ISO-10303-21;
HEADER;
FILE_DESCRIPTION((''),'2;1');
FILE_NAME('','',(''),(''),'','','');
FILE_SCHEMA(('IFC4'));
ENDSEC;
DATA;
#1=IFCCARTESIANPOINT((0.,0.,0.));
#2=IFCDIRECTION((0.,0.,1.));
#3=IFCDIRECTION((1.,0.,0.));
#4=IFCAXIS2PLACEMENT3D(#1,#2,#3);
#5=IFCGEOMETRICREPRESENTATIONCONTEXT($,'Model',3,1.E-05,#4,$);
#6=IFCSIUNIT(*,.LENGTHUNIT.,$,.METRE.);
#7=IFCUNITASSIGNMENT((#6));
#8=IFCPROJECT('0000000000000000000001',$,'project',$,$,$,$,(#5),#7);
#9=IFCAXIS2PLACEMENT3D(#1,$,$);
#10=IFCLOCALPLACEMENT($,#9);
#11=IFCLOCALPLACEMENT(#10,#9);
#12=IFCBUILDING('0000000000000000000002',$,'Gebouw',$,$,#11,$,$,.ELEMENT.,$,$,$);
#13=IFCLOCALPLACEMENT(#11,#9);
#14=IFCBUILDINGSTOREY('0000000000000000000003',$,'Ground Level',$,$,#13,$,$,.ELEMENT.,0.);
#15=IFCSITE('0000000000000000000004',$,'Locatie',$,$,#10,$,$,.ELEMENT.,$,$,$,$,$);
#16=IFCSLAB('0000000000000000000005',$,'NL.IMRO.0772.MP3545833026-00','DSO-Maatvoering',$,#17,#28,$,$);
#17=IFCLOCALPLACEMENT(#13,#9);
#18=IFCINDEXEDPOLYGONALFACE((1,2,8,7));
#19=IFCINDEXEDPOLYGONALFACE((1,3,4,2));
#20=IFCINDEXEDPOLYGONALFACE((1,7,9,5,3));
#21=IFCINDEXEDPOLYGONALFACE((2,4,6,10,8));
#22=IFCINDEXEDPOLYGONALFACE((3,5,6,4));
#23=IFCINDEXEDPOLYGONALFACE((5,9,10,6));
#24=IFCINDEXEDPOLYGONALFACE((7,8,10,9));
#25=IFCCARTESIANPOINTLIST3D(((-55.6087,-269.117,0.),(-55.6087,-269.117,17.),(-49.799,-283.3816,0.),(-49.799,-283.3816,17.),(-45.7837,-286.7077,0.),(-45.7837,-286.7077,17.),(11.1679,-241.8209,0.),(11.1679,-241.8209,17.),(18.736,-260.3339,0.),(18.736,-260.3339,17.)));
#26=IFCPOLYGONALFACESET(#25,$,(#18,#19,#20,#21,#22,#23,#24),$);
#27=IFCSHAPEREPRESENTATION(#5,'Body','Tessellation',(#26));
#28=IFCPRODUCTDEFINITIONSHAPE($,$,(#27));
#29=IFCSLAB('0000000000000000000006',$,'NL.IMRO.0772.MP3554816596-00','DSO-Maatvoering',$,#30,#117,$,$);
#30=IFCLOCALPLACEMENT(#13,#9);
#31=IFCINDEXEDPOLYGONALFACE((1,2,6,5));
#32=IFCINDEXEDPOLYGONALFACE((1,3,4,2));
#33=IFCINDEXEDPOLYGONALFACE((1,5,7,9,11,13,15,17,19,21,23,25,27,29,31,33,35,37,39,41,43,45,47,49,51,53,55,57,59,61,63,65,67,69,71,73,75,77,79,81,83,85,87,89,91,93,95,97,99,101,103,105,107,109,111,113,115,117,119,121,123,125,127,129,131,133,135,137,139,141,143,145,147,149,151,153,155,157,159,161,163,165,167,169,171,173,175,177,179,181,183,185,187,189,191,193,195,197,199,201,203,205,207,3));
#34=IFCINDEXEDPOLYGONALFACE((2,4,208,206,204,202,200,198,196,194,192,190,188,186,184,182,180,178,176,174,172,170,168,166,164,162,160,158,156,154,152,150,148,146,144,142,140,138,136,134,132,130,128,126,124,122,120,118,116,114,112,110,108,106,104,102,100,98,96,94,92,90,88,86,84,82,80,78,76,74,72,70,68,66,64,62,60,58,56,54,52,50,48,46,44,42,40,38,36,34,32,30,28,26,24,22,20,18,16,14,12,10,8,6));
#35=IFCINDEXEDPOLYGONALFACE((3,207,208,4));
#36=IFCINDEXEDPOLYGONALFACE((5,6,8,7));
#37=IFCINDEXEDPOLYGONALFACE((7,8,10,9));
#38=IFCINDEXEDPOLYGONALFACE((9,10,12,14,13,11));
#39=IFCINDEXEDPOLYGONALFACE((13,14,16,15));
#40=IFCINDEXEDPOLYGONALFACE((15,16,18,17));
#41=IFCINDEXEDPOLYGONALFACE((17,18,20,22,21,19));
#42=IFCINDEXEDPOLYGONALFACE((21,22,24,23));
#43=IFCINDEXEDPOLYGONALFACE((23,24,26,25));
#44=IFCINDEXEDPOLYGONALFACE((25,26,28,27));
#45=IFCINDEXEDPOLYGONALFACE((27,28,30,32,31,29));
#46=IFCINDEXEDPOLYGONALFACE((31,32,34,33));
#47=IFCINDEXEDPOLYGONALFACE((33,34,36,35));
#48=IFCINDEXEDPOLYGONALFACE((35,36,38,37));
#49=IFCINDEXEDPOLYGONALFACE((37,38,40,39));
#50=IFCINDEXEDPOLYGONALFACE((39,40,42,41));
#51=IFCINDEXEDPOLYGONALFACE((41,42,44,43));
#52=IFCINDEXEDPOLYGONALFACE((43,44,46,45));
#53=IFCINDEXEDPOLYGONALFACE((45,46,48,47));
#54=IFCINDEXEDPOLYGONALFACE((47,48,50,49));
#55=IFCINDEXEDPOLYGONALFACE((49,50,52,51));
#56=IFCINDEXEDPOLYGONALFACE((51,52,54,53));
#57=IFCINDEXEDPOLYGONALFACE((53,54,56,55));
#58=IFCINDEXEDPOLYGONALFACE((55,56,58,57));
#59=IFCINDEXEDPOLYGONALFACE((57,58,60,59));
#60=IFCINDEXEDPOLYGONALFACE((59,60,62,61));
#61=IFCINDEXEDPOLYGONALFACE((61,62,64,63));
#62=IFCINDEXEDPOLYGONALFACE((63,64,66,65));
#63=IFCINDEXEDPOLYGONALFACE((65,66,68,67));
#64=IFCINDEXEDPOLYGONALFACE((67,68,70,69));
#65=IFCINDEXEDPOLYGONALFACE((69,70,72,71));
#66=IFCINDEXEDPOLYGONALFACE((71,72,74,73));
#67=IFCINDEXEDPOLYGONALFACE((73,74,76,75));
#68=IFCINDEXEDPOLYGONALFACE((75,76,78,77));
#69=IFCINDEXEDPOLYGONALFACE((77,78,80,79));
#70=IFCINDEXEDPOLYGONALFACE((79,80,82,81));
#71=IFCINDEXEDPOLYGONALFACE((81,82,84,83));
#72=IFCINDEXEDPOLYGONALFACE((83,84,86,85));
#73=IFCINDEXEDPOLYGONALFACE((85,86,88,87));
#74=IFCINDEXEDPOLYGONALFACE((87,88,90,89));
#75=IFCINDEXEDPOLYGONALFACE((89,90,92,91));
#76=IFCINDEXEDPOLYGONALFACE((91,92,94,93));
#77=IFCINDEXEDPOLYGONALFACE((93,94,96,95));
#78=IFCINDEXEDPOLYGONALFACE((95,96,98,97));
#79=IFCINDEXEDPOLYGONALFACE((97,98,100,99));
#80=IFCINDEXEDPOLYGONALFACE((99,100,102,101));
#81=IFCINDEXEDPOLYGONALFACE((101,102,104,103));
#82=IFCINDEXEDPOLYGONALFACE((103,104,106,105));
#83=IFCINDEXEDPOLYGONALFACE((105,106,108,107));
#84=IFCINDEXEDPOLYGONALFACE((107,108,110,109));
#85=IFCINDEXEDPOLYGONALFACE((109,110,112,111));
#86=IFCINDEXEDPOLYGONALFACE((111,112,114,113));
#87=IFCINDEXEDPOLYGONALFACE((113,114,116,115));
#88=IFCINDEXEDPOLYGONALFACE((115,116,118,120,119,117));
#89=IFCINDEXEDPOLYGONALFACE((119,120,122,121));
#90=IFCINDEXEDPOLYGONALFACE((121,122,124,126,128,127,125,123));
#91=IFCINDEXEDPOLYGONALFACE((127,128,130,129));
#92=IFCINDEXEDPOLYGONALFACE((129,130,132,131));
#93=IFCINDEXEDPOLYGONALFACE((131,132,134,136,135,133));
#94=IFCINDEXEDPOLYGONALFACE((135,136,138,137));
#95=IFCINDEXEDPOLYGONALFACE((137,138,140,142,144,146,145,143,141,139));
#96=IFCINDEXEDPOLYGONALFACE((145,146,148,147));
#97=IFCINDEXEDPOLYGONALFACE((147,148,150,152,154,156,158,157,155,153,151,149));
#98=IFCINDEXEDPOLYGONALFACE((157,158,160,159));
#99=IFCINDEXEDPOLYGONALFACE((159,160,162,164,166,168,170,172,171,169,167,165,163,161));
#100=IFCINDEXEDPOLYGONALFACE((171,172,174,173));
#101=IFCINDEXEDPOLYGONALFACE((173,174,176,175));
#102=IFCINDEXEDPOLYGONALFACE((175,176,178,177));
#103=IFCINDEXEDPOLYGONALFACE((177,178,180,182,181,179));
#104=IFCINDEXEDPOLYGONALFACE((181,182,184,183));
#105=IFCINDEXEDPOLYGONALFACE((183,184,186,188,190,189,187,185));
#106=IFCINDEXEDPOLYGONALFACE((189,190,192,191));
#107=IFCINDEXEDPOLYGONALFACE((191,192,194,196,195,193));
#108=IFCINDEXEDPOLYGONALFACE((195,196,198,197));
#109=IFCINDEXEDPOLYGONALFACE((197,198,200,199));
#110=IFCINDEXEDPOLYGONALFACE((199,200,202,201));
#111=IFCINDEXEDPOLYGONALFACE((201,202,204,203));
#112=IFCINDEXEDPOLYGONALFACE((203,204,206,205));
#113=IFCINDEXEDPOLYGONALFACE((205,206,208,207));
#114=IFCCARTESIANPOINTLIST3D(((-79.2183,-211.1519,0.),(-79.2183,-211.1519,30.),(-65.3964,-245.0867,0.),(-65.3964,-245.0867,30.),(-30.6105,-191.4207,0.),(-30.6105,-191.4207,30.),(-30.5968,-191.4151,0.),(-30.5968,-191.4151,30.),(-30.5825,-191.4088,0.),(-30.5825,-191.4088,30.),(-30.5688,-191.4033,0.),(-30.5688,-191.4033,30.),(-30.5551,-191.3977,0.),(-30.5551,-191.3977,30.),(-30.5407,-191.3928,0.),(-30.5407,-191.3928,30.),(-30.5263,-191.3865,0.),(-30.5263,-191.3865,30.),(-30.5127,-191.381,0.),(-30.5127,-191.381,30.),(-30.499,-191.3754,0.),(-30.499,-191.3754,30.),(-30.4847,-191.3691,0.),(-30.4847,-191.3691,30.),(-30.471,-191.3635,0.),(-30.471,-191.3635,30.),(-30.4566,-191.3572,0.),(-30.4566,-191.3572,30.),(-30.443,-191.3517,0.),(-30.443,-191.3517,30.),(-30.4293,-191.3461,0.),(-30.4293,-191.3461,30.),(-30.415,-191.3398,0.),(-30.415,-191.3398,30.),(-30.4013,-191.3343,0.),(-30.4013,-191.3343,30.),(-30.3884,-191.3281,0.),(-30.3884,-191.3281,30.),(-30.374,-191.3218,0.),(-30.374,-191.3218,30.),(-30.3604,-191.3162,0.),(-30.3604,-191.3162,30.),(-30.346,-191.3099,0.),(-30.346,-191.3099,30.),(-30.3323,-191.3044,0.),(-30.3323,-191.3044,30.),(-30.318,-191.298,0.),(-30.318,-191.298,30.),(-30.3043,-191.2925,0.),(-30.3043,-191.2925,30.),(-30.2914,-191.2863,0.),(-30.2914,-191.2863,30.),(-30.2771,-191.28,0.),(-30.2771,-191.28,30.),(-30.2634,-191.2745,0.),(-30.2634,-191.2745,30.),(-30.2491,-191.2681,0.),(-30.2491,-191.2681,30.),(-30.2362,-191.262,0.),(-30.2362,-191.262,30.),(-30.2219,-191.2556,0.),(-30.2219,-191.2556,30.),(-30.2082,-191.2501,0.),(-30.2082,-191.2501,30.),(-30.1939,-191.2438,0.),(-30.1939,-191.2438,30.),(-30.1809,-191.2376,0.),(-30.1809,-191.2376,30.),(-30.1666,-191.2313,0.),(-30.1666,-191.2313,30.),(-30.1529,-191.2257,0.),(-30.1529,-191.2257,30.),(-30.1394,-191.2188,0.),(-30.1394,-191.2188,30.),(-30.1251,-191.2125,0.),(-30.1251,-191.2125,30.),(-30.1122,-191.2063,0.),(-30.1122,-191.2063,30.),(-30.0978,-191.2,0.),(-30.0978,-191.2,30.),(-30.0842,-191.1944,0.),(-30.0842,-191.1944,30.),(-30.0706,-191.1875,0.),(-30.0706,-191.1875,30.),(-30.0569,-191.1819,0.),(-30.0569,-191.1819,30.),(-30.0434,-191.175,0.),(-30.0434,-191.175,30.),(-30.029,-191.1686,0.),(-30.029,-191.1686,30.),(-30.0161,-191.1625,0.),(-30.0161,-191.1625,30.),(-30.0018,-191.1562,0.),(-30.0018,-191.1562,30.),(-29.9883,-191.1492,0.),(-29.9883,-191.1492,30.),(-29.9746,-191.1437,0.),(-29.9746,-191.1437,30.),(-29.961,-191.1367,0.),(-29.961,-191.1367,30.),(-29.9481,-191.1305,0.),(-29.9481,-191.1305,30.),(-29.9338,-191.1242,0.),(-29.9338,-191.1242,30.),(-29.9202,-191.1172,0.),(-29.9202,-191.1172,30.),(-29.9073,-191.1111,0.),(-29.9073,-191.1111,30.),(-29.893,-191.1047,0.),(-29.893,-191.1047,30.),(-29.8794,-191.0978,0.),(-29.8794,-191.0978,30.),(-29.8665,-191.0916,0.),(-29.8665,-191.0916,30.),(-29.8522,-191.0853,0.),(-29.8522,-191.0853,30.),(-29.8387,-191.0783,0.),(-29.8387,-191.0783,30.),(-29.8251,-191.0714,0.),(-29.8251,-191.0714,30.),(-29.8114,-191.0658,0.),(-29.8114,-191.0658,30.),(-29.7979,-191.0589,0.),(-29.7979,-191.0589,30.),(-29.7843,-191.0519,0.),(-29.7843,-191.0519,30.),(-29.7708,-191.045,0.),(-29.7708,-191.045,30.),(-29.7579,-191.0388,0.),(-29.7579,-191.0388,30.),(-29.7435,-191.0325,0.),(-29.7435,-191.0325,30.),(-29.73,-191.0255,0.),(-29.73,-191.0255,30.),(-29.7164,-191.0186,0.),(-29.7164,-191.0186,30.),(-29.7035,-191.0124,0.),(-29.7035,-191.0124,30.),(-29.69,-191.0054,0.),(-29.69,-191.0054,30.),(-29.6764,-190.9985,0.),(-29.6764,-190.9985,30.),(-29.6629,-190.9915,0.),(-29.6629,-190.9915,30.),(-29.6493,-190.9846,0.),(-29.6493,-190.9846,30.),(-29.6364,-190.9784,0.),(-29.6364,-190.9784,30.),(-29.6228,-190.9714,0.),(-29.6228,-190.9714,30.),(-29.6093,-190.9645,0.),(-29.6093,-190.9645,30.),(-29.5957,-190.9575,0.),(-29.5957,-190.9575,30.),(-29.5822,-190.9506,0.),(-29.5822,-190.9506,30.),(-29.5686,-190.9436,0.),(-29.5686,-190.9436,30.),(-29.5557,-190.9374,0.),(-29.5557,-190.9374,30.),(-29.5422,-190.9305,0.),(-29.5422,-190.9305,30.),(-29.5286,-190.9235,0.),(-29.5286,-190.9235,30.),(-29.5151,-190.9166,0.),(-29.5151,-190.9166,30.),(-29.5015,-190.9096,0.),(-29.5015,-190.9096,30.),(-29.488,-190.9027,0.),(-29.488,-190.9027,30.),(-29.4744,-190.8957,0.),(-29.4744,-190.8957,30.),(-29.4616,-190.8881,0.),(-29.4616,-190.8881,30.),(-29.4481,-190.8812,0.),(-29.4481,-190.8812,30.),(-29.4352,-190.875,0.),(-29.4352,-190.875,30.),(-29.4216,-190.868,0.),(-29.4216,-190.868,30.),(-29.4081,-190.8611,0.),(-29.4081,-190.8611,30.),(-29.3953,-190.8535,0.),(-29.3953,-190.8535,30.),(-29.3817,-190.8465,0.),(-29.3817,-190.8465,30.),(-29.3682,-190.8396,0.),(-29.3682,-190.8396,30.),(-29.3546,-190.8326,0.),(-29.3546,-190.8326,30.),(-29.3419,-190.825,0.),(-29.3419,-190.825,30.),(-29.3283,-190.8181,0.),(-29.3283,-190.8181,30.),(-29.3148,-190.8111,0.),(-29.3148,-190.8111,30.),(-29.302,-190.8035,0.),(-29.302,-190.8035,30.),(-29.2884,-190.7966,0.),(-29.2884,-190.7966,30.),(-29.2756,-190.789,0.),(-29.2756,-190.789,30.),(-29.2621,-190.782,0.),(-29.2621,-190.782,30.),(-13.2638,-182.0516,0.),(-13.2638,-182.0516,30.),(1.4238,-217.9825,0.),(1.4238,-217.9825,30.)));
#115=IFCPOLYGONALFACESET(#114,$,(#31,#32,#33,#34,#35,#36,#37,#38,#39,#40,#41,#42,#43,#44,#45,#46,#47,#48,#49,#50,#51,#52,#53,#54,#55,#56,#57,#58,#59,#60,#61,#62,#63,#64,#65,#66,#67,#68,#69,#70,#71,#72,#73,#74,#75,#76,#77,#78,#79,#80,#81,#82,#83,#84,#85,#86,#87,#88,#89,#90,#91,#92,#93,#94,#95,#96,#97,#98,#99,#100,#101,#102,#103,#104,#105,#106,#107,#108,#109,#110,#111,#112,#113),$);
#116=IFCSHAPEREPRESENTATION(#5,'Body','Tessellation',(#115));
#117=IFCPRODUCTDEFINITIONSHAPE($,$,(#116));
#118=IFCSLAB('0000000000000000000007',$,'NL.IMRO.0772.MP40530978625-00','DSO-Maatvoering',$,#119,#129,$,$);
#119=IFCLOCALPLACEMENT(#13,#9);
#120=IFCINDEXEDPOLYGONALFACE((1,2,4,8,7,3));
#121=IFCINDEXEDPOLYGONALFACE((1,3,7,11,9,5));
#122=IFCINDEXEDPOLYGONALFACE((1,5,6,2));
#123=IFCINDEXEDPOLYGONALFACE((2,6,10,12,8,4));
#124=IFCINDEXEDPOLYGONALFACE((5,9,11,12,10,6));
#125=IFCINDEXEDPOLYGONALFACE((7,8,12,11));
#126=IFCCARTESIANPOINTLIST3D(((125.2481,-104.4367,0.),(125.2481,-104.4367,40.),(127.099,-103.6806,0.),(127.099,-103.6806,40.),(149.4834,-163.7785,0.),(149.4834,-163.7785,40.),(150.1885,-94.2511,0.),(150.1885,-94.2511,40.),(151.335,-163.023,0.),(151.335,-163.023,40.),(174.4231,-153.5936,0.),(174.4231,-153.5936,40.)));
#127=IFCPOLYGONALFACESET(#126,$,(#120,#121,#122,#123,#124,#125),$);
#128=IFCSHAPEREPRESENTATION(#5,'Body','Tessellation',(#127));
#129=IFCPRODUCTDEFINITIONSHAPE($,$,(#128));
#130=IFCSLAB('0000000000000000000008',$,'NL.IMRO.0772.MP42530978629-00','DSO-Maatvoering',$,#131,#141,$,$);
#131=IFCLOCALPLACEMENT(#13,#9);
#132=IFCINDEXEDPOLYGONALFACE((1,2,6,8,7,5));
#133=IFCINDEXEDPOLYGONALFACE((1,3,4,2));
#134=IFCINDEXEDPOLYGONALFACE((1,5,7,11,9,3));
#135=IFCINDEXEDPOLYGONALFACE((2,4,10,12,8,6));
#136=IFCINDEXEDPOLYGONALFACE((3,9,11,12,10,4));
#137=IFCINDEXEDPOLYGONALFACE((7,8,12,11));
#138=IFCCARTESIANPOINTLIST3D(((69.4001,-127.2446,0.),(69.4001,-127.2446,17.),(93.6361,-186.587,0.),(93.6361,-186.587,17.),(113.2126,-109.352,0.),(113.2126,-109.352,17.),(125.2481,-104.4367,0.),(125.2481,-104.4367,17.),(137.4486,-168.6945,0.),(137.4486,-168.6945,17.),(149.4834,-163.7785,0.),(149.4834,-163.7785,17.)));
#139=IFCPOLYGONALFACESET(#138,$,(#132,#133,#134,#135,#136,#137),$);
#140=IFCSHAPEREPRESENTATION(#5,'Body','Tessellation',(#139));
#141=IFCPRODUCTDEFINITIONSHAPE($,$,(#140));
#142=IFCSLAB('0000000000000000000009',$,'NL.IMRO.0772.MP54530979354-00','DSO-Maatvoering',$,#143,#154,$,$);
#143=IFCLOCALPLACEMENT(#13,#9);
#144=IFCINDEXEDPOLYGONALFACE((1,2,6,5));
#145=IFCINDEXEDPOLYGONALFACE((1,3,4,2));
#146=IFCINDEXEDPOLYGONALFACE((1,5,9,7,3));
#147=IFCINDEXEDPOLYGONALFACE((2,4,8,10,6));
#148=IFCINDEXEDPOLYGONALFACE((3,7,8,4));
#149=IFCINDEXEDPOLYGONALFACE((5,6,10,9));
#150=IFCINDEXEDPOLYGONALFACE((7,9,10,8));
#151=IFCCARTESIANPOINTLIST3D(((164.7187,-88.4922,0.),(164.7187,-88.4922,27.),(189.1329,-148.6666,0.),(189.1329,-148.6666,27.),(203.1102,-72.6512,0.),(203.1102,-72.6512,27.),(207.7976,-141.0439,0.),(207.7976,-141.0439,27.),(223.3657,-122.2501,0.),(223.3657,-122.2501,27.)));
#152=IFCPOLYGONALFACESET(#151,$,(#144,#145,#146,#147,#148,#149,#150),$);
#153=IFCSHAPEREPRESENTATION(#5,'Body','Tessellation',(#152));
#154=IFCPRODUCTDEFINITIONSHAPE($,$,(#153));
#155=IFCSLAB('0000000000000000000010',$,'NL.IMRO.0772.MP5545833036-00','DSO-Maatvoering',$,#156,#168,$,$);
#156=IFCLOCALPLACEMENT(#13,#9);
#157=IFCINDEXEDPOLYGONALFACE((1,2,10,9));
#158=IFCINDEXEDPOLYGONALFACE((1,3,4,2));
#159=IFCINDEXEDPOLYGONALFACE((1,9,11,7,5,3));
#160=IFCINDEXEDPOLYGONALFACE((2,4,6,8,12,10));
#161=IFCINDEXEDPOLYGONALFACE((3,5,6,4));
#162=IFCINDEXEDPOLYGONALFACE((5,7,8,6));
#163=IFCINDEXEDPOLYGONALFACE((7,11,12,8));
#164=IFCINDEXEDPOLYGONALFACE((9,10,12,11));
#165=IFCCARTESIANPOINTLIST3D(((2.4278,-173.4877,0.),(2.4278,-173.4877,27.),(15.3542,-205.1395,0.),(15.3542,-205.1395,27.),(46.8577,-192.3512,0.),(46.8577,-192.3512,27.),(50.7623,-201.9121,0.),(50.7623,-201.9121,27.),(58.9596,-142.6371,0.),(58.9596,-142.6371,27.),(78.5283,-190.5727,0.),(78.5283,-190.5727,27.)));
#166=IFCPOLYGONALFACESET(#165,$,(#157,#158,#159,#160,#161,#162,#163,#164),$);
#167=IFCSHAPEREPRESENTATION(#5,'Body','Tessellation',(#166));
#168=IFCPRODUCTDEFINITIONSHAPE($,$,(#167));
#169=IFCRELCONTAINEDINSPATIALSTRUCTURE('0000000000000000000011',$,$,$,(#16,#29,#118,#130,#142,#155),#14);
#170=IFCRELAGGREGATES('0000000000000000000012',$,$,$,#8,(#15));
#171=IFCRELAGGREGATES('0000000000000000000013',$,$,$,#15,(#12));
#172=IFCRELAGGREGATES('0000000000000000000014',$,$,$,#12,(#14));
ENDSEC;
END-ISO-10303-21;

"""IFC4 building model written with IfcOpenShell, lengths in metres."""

from ifc_helpers import new_model, si_unit, origin, origin_with_axes, place, context, project, spatial, polyline, outline, extrude, element, save


model = new_model("IFC4")

# Units and contexts
model_context = context("Model", 3, precision=1e-05, world=origin_with_axes())
ifc_project = project(units=[si_unit("LENGTHUNIT", "METRE")], contexts=[model_context])

# Site, building, storey
site_placement = place(None, origin())
site = spatial("IfcSite", under=ifc_project, at=site_placement, Name="Locatie", CompositionType="ELEMENT")
building_placement = place(site_placement, origin())
building = spatial("IfcBuilding", under=site, at=building_placement, Name="Gebouw", CompositionType="ELEMENT")
storey_placement = place(building_placement, origin())
storey = spatial("IfcBuildingStorey", under=building, at=storey_placement, Name="Ground Level", CompositionType="ELEMENT", Elevation=0.0)

# Slabs
slab_1_placement = place(storey_placement, origin())
element("IfcSlab", 1, at=slab_1_placement, inside=storey, Name="NL.IMRO.0772.MP3545833026-00", Description="DSO-Maatvoering", context=model_context, shape_type="SweptSolid", body=[
    extrude(outline(polyline([(-55.6087, -269.117), (11.1679, -241.8209), (18.736, -260.3339), (-45.7837, -286.7077), (-49.799, -283.3816), (-55.6087, -269.117)])), origin_with_axes(), (0.0, 0.0, 1.0), 17.0),
])
slab_2_placement = place(storey_placement, origin())
element("IfcSlab", 2, at=slab_2_placement, inside=storey, Name="NL.IMRO.0772.MP3554816596-00", Description="DSO-Maatvoering", context=model_context, shape_type="SweptSolid", body=[
    extrude(outline(polyline([(-13.2638, -182.0516), (1.4238, -217.9825), (-65.3964, -245.0867), (-79.2183, -211.1519), (-30.6105, -191.4207), (-30.5968, -191.4151), (-30.5825, -191.4088), (-30.5688, -191.4033), (-30.5551, -191.3977), (-30.5407, -191.3928), (-30.5263, -191.3865), (-30.5127, -191.381), (-30.499, -191.3754), (-30.4847, -191.3691), (-30.471, -191.3635), (-30.4566, -191.3572), (-30.443, -191.3517), (-30.4293, -191.3461), (-30.415, -191.3398), (-30.4013, -191.3343), (-30.3884, -191.3281), (-30.374, -191.3218), (-30.3604, -191.3162), (-30.346, -191.3099), (-30.3323, -191.3044), (-30.318, -191.298), (-30.3043, -191.2925), (-30.2914, -191.2863), (-30.2771, -191.28), (-30.2634, -191.2745), (-30.2491, -191.2681), (-30.2362, -191.262), (-30.2219, -191.2556), (-30.2082, -191.2501), (-30.1939, -191.2438), (-30.1809, -191.2376), (-30.1666, -191.2313), (-30.1529, -191.2257), (-30.1394, -191.2188), (-30.1251, -191.2125), (-30.1122, -191.2063), (-30.0978, -191.2), (-30.0842, -191.1944), (-30.0706, -191.1875), (-30.0569, -191.1819), (-30.0434, -191.175), (-30.029, -191.1686), (-30.0161, -191.1625), (-30.0018, -191.1562), (-29.9883, -191.1492), (-29.9746, -191.1437), (-29.961, -191.1367), (-29.9481, -191.1305), (-29.9338, -191.1242), (-29.9202, -191.1172), (-29.9073, -191.1111), (-29.893, -191.1047), (-29.8794, -191.0978), (-29.8665, -191.0916), (-29.8522, -191.0853), (-29.8387, -191.0783), (-29.8251, -191.0714), (-29.8114, -191.0658), (-29.7979, -191.0589), (-29.7843, -191.0519), (-29.7708, -191.045), (-29.7579, -191.0388), (-29.7435, -191.0325), (-29.73, -191.0255), (-29.7164, -191.0186), (-29.7035, -191.0124), (-29.69, -191.0054), (-29.6764, -190.9985), (-29.6629, -190.9915), (-29.6493, -190.9846), (-29.6364, -190.9784), (-29.6228, -190.9714), (-29.6093, -190.9645), (-29.5957, -190.9575), (-29.5822, -190.9506), (-29.5686, -190.9436), (-29.5557, -190.9374), (-29.5422, -190.9305), (-29.5286, -190.9235), (-29.5151, -190.9166), (-29.5015, -190.9096), (-29.488, -190.9027), (-29.4744, -190.8957), (-29.4616, -190.8881), (-29.4481, -190.8812), (-29.4352, -190.875), (-29.4216, -190.868), (-29.4081, -190.8611), (-29.3953, -190.8535), (-29.3817, -190.8465), (-29.3682, -190.8396), (-29.3546, -190.8326), (-29.3419, -190.825), (-29.3283, -190.8181), (-29.3148, -190.8111), (-29.302, -190.8035), (-29.2884, -190.7966), (-29.2756, -190.789), (-29.2621, -190.782), (-13.2638, -182.0516)])), origin_with_axes(), (0.0, 0.0, 1.0), 30.0),
])
slab_3_placement = place(storey_placement, origin())
element("IfcSlab", 3, at=slab_3_placement, inside=storey, Name="NL.IMRO.0772.MP40530978625-00", Description="DSO-Maatvoering", context=model_context, shape_type="SweptSolid", body=[
    extrude(outline(polyline([(125.2481, -104.4367), (127.099, -103.6806), (150.1885, -94.2511), (174.4231, -153.5936), (151.335, -163.023), (149.4834, -163.7785), (125.2481, -104.4367)])), origin_with_axes(), (0.0, 0.0, 1.0), 40.0),
])
slab_4_placement = place(storey_placement, origin())
element("IfcSlab", 4, at=slab_4_placement, inside=storey, Name="NL.IMRO.0772.MP42530978629-00", Description="DSO-Maatvoering", context=model_context, shape_type="SweptSolid", body=[
    extrude(outline(polyline([(149.4834, -163.7785), (137.4486, -168.6945), (93.6361, -186.587), (69.4001, -127.2446), (113.2126, -109.352), (125.2481, -104.4367), (149.4834, -163.7785)])), origin_with_axes(), (0.0, 0.0, 1.0), 17.0),
])
slab_5_placement = place(storey_placement, origin())
element("IfcSlab", 5, at=slab_5_placement, inside=storey, Name="NL.IMRO.0772.MP54530979354-00", Description="DSO-Maatvoering", context=model_context, shape_type="SweptSolid", body=[
    extrude(outline(polyline([(189.1329, -148.6666), (164.7187, -88.4922), (203.1102, -72.6512), (223.3657, -122.2501), (207.7976, -141.0439), (189.1329, -148.6666)])), origin_with_axes(), (0.0, 0.0, 1.0), 27.0),
])
slab_6_placement = place(storey_placement, origin())
element("IfcSlab", 6, at=slab_6_placement, inside=storey, Name="NL.IMRO.0772.MP5545833036-00", Description="DSO-Maatvoering", context=model_context, shape_type="SweptSolid", body=[
    extrude(outline(polyline([(78.5283, -190.5727), (50.7623, -201.9121), (46.8577, -192.3512), (15.3542, -205.1395), (2.4278, -173.4877), (58.9596, -142.6371), (78.5283, -190.5727)])), origin_with_axes(), (0.0, 0.0, 1.0), 27.0),
])

save(model, "model.ifc")
